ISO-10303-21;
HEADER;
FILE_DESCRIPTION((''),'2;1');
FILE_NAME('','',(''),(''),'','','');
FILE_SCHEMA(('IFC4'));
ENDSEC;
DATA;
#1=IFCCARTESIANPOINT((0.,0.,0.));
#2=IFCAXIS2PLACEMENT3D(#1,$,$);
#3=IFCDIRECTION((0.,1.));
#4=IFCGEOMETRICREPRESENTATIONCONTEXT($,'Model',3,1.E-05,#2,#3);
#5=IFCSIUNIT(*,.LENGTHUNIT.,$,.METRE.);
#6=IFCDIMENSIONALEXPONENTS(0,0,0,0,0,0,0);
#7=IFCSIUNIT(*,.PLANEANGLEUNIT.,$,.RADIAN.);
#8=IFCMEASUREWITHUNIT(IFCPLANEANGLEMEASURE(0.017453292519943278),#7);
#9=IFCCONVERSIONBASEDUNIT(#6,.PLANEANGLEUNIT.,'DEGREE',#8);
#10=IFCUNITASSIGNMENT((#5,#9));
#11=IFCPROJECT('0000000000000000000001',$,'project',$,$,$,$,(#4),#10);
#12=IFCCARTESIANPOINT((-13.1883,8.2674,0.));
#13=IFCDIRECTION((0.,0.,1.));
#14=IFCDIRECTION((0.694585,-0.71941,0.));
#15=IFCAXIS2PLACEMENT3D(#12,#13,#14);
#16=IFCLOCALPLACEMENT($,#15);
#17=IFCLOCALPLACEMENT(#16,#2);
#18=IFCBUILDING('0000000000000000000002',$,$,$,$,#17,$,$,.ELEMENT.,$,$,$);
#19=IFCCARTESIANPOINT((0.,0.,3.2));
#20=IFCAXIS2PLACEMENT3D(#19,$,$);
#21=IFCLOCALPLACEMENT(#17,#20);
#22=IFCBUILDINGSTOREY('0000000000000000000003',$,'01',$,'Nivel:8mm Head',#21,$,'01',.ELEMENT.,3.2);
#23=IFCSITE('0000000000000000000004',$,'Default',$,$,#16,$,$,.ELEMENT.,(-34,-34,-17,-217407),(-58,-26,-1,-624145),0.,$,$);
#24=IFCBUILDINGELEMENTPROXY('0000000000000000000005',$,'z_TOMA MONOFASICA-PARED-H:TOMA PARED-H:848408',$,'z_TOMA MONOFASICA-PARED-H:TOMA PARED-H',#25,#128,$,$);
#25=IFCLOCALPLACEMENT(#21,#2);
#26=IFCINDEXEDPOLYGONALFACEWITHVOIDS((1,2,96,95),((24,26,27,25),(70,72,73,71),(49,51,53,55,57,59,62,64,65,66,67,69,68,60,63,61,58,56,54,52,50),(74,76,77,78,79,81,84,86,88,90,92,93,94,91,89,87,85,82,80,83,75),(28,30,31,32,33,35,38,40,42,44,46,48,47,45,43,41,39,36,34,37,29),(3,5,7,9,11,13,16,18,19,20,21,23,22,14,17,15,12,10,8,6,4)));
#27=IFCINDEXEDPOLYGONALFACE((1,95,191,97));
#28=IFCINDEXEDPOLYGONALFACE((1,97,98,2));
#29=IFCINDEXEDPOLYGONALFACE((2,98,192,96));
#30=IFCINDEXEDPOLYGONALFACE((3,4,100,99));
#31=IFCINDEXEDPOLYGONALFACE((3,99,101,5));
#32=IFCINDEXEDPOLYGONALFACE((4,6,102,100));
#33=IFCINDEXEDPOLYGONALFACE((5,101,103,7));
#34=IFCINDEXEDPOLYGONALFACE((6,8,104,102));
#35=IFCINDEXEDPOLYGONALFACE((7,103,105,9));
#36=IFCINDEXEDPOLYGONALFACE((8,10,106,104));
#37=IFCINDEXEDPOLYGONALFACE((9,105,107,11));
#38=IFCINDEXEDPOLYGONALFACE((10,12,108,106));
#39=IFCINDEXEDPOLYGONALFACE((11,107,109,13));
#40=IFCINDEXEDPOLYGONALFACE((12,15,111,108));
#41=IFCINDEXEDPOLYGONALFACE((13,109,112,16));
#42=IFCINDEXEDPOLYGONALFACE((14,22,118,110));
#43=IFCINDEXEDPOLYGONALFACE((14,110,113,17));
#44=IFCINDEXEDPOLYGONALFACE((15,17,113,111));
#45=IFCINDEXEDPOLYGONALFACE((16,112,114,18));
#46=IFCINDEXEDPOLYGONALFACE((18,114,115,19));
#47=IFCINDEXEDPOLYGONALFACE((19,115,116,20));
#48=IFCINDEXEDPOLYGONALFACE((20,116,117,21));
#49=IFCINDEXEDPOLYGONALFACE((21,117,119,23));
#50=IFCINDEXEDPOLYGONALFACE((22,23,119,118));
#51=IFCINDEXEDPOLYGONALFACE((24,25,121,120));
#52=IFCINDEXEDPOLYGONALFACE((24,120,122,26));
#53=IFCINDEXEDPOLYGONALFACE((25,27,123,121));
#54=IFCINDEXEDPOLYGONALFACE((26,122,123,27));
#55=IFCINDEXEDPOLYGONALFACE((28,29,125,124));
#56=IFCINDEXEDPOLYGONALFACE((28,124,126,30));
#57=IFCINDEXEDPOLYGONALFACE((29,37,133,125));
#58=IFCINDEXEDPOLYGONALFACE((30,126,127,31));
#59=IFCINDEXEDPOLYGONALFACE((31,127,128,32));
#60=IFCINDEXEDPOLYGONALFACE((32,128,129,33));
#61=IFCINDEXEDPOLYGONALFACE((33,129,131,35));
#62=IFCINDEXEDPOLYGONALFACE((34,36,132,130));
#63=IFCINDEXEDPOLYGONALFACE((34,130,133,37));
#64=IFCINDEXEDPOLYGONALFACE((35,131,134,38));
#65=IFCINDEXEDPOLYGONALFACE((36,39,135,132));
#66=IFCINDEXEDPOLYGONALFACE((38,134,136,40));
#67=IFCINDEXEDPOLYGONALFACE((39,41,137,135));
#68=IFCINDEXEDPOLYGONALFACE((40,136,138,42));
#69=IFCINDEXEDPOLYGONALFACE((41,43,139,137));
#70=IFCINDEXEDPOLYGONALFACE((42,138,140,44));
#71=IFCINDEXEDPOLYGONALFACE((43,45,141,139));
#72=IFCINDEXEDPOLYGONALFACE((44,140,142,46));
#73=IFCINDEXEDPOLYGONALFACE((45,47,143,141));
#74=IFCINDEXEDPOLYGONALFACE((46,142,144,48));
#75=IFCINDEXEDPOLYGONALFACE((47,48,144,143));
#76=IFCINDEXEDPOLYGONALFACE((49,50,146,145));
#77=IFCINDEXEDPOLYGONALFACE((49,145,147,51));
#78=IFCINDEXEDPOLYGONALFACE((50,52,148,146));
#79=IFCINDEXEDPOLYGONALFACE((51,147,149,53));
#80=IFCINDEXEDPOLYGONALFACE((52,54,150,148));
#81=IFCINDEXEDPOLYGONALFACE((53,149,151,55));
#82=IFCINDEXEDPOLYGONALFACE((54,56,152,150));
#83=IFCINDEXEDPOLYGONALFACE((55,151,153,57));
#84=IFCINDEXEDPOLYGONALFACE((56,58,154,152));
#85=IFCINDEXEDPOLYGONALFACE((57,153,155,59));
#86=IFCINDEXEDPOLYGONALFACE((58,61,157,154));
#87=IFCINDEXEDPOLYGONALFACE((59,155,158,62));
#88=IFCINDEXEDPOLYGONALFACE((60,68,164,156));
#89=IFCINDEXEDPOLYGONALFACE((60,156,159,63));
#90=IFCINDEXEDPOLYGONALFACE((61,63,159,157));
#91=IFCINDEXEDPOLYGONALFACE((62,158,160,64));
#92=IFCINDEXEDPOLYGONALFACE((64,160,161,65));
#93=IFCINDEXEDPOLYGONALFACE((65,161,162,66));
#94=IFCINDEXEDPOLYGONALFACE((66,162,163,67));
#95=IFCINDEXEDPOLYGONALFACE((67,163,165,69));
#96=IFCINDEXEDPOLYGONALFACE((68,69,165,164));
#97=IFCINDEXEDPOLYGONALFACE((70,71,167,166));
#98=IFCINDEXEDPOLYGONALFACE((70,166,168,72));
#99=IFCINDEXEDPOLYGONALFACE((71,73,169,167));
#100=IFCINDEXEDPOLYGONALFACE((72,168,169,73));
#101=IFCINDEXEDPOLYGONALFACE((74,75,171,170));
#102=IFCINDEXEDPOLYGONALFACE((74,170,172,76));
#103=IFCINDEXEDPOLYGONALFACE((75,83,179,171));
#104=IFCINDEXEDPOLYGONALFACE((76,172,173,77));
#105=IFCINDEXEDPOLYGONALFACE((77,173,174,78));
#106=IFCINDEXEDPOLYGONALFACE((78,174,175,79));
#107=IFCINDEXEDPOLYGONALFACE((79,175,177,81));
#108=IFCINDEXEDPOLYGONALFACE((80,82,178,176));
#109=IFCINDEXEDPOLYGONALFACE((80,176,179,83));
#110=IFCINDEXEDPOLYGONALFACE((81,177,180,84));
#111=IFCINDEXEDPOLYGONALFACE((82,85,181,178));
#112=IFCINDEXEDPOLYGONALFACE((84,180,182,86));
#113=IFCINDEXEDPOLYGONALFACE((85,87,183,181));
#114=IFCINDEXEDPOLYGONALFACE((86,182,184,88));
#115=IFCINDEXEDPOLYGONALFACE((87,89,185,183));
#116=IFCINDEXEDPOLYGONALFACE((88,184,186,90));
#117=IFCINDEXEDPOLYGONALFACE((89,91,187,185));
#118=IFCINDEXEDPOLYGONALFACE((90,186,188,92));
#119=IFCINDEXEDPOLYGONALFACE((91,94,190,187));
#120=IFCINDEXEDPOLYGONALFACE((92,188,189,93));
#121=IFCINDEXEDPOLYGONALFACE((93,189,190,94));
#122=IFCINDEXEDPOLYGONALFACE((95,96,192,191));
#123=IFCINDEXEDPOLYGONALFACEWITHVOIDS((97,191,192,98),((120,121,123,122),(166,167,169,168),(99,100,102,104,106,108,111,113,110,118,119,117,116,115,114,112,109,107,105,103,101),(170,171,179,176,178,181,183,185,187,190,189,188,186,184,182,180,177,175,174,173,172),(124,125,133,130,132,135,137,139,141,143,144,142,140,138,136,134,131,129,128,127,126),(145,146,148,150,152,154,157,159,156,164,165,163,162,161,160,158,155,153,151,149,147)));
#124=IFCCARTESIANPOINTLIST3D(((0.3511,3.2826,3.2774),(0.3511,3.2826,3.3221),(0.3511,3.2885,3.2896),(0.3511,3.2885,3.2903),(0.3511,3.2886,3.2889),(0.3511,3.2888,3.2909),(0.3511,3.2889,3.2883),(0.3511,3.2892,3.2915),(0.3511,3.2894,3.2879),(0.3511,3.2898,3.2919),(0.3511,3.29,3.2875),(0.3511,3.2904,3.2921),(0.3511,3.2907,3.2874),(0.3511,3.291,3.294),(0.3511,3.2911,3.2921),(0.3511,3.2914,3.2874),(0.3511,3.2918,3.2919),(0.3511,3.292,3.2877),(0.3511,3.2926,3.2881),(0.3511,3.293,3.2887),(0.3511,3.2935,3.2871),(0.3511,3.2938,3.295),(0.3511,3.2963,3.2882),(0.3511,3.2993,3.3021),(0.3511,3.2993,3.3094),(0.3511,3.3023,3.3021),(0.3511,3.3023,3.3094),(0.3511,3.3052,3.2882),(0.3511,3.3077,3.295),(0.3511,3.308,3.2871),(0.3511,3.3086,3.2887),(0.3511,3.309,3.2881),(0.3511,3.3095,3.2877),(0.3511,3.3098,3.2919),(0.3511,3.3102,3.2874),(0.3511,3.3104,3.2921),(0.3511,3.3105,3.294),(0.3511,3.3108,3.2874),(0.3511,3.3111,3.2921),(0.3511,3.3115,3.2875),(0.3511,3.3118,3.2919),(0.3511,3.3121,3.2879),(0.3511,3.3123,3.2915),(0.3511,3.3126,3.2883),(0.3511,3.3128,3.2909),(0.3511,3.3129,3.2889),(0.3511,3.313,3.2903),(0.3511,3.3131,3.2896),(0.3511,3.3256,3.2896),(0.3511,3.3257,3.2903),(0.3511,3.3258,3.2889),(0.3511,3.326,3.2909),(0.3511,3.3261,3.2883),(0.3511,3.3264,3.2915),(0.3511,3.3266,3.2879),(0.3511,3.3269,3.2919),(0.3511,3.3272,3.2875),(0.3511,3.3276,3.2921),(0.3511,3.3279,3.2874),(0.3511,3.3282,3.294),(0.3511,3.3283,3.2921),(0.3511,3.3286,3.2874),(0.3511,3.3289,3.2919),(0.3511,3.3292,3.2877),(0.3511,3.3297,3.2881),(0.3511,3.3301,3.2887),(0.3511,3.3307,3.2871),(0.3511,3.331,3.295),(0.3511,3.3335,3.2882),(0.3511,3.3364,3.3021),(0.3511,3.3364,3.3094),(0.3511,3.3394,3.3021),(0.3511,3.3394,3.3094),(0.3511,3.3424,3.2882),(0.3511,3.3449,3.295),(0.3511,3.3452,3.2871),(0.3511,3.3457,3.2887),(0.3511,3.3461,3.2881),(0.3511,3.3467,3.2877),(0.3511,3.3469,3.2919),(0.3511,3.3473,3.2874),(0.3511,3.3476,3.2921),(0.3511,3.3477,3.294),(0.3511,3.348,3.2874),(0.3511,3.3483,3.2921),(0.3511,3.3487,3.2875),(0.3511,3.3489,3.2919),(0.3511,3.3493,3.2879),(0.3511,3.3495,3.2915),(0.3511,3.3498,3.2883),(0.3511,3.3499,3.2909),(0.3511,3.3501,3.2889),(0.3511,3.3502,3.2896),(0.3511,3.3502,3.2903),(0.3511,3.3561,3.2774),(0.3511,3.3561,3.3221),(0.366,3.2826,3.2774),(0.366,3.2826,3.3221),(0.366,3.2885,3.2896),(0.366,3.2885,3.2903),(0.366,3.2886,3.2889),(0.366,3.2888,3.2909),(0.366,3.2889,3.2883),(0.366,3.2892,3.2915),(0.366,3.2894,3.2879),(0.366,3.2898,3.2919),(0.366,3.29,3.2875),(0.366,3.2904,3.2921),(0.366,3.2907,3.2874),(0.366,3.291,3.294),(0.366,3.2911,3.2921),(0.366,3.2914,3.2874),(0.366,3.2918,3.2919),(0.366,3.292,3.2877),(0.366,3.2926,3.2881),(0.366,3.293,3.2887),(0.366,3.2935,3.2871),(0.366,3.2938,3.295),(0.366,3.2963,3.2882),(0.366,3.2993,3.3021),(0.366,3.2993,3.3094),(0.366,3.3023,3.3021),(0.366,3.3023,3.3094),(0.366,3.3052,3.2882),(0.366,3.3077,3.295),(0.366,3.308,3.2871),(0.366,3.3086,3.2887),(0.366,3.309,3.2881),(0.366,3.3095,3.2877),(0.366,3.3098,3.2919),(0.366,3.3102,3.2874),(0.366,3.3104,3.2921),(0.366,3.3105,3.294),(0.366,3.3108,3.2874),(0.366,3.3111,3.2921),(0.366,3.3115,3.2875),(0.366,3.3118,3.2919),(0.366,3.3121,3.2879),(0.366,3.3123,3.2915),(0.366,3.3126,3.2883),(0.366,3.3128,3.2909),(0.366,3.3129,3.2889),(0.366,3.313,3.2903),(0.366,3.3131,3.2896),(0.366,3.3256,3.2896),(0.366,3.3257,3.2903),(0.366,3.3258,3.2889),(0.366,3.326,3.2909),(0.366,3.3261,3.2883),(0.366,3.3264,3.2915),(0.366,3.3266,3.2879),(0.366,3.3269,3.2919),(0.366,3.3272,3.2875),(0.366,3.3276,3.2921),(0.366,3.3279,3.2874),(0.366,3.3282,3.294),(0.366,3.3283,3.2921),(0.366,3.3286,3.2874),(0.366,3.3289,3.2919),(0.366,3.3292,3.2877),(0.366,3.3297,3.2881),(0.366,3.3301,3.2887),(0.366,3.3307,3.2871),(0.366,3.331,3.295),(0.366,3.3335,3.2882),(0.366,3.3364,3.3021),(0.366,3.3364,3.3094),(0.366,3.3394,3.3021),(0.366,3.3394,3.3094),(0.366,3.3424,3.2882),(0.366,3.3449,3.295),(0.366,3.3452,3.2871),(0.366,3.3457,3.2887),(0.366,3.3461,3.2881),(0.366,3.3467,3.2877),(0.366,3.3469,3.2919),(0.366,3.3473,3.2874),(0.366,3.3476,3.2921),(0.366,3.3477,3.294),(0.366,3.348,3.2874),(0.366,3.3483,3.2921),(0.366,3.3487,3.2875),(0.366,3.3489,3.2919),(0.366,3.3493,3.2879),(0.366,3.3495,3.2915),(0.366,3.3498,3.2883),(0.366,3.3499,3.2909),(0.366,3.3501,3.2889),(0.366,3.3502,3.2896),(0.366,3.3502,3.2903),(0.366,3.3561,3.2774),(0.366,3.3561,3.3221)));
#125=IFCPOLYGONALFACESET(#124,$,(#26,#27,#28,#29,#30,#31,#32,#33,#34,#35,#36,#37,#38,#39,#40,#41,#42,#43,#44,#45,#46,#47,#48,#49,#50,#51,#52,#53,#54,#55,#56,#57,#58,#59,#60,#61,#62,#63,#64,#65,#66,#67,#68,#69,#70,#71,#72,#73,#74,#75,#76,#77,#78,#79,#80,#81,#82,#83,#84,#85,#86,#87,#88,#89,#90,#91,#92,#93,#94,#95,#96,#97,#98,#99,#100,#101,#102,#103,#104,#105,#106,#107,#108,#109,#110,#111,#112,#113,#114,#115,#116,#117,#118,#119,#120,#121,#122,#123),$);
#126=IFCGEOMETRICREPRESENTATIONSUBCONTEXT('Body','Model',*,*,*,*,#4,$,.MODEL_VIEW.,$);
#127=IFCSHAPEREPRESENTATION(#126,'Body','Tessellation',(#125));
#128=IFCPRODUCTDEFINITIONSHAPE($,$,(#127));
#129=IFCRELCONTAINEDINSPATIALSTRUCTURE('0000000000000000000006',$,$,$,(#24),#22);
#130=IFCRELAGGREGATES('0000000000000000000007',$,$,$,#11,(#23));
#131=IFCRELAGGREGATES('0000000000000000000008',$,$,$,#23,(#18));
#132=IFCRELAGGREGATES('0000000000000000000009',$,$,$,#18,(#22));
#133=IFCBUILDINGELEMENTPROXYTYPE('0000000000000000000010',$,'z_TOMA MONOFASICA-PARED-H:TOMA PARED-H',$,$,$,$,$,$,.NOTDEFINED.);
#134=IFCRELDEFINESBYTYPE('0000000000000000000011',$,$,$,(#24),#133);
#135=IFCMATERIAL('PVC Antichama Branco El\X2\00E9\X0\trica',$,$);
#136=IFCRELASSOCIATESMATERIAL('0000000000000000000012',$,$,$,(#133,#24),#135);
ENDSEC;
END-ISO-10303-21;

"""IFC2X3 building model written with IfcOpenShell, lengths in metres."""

from ifc_helpers import new_model, entity, si_unit, converted_unit, direction, frame, frame_2d, origin, place, context, subcontext, project, spatial, polyline, circle_curve, parameter, trimmed, segment, composite_curve, outline, extrude, source, transform, mapped, material, type_object, type_shapes, element, save


model = new_model("IFC2X3")

# Units and contexts
model_context = context("Model", 3, precision=1e-05, world=origin(), true_north=direction((0.0, 1.0)))
body_context = subcontext(model_context, "Body", "Model", "MODEL_VIEW")
ifc_project = project(units=[si_unit("LENGTHUNIT", "METRE"), converted_unit("PLANEANGLEUNIT", "DEGREE", entity("IfcPlaneAngleMeasure", 0.017453292519943278), si_unit("PLANEANGLEUNIT", "RADIAN"), dimensions=[0, 0, 0, 0, 0, 0, 0])], contexts=[model_context])

# Site, building, storey
site_placement = place(None, frame((-13.1883, 8.2674, 0.0), z_axis=(0.0, 0.0, 1.0), x_axis=(0.694585, -0.71941, 0.0)))
site = spatial("IfcSite", under=ifc_project, at=site_placement, Name="Default", CompositionType="ELEMENT", RefLatitude=(-34, -34, -17, -217407), RefLongitude=(-58, -26, -1, -624145), RefElevation=0.0)
building_placement = place(site_placement, origin())
building = spatial("IfcBuilding", under=site, at=building_placement, CompositionType="ELEMENT")
storey_placement = place(building_placement, frame((0.0, 0.0, 3.2)))
storey = spatial("IfcBuildingStorey", under=building, at=storey_placement, Name="01", ObjectType="Nivel:8mm Head", LongName="01", CompositionType="ELEMENT", Elevation=3.2)

# Building element proxy
ifc_material_1 = material(Name="PVC Antichama Branco Elétrica")
building_element_proxy_type_1 = type_object("IfcBuildingElementProxyType", Name="z_TOMA MONOFASICA-PARED-H:TOMA PARED-H", PredefinedType="NOTDEFINED", material=ifc_material_1)
shared_shape_1 = source(origin(), body_context, "Body", "SweptSolid", [
    extrude(outline(polyline([(-0.0368, -0.0223), (0.0368, -0.0223), (0.0368, 0.0223), (-0.0368, 0.0223), (-0.0368, -0.0223)]), holes=[composite_curve([segment(polyline([(0.0141, 0.0115), (0.0116, 0.0047)]), True, "CONTINUOUS"), segment(polyline([(0.0116, 0.0047), (0.0088, 0.0057)]), True, "CONTINUOUS"), segment(polyline([(0.0088, 0.0057), (0.0096, 0.0078)]), True, "CONTINUOUS"), segment(trimmed(circle_curve(frame_2d((0.0087, 0.0099), x_axis=(1.0, 0.0)), 0.0024), [parameter(27.118901)], [parameter(292.881099)], True, "PARAMETER"), False, "CONTINUOUS"), segment(polyline([(0.0108, 0.011), (0.0113, 0.0126)]), True, "CONTINUOUS"), segment(polyline([(0.0113, 0.0126), (0.0141, 0.0115)]), True, "CONTINUOUS")], self_intersect=False), composite_curve([segment(polyline([(0.0255, 0.0047), (0.023, 0.0115)]), True, "CONTINUOUS"), segment(polyline([(0.023, 0.0115), (0.0258, 0.0126)]), True, "CONTINUOUS"), segment(polyline([(0.0258, 0.0126), (0.0264, 0.011)]), True, "CONTINUOUS"), segment(trimmed(circle_curve(frame_2d((0.0285, 0.0099), x_axis=(1.0, 0.0)), 0.0024), [parameter(247.118901)], [parameter(152.881099)], True, "PARAMETER"), False, "CONTINUOUS"), segment(polyline([(0.0276, 0.0078), (0.0283, 0.0057)]), True, "CONTINUOUS"), segment(polyline([(0.0283, 0.0057), (0.0255, 0.0047)]), True, "CONTINUOUS")], self_intersect=False), polyline([(0.0201, -0.0024), (0.0201, -0.0097), (0.0171, -0.0097), (0.0171, -0.0024), (0.0201, -0.0024)]), composite_curve([segment(polyline([(-0.0141, 0.0115), (-0.0113, 0.0126)]), True, "CONTINUOUS"), segment(polyline([(-0.0113, 0.0126), (-0.0108, 0.011)]), True, "CONTINUOUS"), segment(trimmed(circle_curve(frame_2d((-0.0087, 0.0099), x_axis=(1.0, 0.0)), 0.0024), [parameter(247.118901)], [parameter(152.881099)], True, "PARAMETER"), False, "CONTINUOUS"), segment(polyline([(-0.0096, 0.0078), (-0.0088, 0.0057)]), True, "CONTINUOUS"), segment(polyline([(-0.0088, 0.0057), (-0.0116, 0.0047)]), True, "CONTINUOUS"), segment(polyline([(-0.0116, 0.0047), (-0.0141, 0.0115)]), True, "CONTINUOUS")], self_intersect=False), composite_curve([segment(polyline([(-0.0255, 0.0047), (-0.0283, 0.0057)]), True, "CONTINUOUS"), segment(polyline([(-0.0283, 0.0057), (-0.0276, 0.0078)]), True, "CONTINUOUS"), segment(trimmed(circle_curve(frame_2d((-0.0285, 0.0099), x_axis=(1.0, 0.0)), 0.0024), [parameter(27.118901)], [parameter(292.881099)], True, "PARAMETER"), False, "CONTINUOUS"), segment(polyline([(-0.0264, 0.011), (-0.0258, 0.0126)]), True, "CONTINUOUS"), segment(polyline([(-0.0258, 0.0126), (-0.023, 0.0115)]), True, "CONTINUOUS"), segment(polyline([(-0.023, 0.0115), (-0.0255, 0.0047)]), True, "CONTINUOUS")], self_intersect=False), polyline([(-0.0201, -0.0024), (-0.0171, -0.0024), (-0.0171, -0.0097), (-0.0201, -0.0097), (-0.0201, -0.0024)])]), frame((0.0, -0.005, 0.0223), z_axis=(0.0, 1.0, 0.0), x_axis=(1.0, 0.0, 0.0)), (0.0, 0.0, 1.0), 0.0148),
])
type_shapes(building_element_proxy_type_1, [shared_shape_1])
for number, where, z_axis, x_axis, name in (
    (1, (0.361, 3.3194, 3.2774), (0.0, 0.0, 1.0), (0.0, 1.0, 0.0), "z_TOMA MONOFASICA-PARED-H:TOMA PARED-H:848408"),
):
    element("IfcBuildingElementProxy", number, at=place(storey_placement, frame(where, z_axis=z_axis, x_axis=x_axis)), inside=storey, type_object=building_element_proxy_type_1, material=ifc_material_1, Name=name, ObjectType="z_TOMA MONOFASICA-PARED-H:TOMA PARED-H", context=body_context, shape_type="MappedRepresentation", body=[
        mapped(shared_shape_1, transform((0.0, 0.0, 0.0), scale=1.0)),
    ])

save(model, "model.ifc")
